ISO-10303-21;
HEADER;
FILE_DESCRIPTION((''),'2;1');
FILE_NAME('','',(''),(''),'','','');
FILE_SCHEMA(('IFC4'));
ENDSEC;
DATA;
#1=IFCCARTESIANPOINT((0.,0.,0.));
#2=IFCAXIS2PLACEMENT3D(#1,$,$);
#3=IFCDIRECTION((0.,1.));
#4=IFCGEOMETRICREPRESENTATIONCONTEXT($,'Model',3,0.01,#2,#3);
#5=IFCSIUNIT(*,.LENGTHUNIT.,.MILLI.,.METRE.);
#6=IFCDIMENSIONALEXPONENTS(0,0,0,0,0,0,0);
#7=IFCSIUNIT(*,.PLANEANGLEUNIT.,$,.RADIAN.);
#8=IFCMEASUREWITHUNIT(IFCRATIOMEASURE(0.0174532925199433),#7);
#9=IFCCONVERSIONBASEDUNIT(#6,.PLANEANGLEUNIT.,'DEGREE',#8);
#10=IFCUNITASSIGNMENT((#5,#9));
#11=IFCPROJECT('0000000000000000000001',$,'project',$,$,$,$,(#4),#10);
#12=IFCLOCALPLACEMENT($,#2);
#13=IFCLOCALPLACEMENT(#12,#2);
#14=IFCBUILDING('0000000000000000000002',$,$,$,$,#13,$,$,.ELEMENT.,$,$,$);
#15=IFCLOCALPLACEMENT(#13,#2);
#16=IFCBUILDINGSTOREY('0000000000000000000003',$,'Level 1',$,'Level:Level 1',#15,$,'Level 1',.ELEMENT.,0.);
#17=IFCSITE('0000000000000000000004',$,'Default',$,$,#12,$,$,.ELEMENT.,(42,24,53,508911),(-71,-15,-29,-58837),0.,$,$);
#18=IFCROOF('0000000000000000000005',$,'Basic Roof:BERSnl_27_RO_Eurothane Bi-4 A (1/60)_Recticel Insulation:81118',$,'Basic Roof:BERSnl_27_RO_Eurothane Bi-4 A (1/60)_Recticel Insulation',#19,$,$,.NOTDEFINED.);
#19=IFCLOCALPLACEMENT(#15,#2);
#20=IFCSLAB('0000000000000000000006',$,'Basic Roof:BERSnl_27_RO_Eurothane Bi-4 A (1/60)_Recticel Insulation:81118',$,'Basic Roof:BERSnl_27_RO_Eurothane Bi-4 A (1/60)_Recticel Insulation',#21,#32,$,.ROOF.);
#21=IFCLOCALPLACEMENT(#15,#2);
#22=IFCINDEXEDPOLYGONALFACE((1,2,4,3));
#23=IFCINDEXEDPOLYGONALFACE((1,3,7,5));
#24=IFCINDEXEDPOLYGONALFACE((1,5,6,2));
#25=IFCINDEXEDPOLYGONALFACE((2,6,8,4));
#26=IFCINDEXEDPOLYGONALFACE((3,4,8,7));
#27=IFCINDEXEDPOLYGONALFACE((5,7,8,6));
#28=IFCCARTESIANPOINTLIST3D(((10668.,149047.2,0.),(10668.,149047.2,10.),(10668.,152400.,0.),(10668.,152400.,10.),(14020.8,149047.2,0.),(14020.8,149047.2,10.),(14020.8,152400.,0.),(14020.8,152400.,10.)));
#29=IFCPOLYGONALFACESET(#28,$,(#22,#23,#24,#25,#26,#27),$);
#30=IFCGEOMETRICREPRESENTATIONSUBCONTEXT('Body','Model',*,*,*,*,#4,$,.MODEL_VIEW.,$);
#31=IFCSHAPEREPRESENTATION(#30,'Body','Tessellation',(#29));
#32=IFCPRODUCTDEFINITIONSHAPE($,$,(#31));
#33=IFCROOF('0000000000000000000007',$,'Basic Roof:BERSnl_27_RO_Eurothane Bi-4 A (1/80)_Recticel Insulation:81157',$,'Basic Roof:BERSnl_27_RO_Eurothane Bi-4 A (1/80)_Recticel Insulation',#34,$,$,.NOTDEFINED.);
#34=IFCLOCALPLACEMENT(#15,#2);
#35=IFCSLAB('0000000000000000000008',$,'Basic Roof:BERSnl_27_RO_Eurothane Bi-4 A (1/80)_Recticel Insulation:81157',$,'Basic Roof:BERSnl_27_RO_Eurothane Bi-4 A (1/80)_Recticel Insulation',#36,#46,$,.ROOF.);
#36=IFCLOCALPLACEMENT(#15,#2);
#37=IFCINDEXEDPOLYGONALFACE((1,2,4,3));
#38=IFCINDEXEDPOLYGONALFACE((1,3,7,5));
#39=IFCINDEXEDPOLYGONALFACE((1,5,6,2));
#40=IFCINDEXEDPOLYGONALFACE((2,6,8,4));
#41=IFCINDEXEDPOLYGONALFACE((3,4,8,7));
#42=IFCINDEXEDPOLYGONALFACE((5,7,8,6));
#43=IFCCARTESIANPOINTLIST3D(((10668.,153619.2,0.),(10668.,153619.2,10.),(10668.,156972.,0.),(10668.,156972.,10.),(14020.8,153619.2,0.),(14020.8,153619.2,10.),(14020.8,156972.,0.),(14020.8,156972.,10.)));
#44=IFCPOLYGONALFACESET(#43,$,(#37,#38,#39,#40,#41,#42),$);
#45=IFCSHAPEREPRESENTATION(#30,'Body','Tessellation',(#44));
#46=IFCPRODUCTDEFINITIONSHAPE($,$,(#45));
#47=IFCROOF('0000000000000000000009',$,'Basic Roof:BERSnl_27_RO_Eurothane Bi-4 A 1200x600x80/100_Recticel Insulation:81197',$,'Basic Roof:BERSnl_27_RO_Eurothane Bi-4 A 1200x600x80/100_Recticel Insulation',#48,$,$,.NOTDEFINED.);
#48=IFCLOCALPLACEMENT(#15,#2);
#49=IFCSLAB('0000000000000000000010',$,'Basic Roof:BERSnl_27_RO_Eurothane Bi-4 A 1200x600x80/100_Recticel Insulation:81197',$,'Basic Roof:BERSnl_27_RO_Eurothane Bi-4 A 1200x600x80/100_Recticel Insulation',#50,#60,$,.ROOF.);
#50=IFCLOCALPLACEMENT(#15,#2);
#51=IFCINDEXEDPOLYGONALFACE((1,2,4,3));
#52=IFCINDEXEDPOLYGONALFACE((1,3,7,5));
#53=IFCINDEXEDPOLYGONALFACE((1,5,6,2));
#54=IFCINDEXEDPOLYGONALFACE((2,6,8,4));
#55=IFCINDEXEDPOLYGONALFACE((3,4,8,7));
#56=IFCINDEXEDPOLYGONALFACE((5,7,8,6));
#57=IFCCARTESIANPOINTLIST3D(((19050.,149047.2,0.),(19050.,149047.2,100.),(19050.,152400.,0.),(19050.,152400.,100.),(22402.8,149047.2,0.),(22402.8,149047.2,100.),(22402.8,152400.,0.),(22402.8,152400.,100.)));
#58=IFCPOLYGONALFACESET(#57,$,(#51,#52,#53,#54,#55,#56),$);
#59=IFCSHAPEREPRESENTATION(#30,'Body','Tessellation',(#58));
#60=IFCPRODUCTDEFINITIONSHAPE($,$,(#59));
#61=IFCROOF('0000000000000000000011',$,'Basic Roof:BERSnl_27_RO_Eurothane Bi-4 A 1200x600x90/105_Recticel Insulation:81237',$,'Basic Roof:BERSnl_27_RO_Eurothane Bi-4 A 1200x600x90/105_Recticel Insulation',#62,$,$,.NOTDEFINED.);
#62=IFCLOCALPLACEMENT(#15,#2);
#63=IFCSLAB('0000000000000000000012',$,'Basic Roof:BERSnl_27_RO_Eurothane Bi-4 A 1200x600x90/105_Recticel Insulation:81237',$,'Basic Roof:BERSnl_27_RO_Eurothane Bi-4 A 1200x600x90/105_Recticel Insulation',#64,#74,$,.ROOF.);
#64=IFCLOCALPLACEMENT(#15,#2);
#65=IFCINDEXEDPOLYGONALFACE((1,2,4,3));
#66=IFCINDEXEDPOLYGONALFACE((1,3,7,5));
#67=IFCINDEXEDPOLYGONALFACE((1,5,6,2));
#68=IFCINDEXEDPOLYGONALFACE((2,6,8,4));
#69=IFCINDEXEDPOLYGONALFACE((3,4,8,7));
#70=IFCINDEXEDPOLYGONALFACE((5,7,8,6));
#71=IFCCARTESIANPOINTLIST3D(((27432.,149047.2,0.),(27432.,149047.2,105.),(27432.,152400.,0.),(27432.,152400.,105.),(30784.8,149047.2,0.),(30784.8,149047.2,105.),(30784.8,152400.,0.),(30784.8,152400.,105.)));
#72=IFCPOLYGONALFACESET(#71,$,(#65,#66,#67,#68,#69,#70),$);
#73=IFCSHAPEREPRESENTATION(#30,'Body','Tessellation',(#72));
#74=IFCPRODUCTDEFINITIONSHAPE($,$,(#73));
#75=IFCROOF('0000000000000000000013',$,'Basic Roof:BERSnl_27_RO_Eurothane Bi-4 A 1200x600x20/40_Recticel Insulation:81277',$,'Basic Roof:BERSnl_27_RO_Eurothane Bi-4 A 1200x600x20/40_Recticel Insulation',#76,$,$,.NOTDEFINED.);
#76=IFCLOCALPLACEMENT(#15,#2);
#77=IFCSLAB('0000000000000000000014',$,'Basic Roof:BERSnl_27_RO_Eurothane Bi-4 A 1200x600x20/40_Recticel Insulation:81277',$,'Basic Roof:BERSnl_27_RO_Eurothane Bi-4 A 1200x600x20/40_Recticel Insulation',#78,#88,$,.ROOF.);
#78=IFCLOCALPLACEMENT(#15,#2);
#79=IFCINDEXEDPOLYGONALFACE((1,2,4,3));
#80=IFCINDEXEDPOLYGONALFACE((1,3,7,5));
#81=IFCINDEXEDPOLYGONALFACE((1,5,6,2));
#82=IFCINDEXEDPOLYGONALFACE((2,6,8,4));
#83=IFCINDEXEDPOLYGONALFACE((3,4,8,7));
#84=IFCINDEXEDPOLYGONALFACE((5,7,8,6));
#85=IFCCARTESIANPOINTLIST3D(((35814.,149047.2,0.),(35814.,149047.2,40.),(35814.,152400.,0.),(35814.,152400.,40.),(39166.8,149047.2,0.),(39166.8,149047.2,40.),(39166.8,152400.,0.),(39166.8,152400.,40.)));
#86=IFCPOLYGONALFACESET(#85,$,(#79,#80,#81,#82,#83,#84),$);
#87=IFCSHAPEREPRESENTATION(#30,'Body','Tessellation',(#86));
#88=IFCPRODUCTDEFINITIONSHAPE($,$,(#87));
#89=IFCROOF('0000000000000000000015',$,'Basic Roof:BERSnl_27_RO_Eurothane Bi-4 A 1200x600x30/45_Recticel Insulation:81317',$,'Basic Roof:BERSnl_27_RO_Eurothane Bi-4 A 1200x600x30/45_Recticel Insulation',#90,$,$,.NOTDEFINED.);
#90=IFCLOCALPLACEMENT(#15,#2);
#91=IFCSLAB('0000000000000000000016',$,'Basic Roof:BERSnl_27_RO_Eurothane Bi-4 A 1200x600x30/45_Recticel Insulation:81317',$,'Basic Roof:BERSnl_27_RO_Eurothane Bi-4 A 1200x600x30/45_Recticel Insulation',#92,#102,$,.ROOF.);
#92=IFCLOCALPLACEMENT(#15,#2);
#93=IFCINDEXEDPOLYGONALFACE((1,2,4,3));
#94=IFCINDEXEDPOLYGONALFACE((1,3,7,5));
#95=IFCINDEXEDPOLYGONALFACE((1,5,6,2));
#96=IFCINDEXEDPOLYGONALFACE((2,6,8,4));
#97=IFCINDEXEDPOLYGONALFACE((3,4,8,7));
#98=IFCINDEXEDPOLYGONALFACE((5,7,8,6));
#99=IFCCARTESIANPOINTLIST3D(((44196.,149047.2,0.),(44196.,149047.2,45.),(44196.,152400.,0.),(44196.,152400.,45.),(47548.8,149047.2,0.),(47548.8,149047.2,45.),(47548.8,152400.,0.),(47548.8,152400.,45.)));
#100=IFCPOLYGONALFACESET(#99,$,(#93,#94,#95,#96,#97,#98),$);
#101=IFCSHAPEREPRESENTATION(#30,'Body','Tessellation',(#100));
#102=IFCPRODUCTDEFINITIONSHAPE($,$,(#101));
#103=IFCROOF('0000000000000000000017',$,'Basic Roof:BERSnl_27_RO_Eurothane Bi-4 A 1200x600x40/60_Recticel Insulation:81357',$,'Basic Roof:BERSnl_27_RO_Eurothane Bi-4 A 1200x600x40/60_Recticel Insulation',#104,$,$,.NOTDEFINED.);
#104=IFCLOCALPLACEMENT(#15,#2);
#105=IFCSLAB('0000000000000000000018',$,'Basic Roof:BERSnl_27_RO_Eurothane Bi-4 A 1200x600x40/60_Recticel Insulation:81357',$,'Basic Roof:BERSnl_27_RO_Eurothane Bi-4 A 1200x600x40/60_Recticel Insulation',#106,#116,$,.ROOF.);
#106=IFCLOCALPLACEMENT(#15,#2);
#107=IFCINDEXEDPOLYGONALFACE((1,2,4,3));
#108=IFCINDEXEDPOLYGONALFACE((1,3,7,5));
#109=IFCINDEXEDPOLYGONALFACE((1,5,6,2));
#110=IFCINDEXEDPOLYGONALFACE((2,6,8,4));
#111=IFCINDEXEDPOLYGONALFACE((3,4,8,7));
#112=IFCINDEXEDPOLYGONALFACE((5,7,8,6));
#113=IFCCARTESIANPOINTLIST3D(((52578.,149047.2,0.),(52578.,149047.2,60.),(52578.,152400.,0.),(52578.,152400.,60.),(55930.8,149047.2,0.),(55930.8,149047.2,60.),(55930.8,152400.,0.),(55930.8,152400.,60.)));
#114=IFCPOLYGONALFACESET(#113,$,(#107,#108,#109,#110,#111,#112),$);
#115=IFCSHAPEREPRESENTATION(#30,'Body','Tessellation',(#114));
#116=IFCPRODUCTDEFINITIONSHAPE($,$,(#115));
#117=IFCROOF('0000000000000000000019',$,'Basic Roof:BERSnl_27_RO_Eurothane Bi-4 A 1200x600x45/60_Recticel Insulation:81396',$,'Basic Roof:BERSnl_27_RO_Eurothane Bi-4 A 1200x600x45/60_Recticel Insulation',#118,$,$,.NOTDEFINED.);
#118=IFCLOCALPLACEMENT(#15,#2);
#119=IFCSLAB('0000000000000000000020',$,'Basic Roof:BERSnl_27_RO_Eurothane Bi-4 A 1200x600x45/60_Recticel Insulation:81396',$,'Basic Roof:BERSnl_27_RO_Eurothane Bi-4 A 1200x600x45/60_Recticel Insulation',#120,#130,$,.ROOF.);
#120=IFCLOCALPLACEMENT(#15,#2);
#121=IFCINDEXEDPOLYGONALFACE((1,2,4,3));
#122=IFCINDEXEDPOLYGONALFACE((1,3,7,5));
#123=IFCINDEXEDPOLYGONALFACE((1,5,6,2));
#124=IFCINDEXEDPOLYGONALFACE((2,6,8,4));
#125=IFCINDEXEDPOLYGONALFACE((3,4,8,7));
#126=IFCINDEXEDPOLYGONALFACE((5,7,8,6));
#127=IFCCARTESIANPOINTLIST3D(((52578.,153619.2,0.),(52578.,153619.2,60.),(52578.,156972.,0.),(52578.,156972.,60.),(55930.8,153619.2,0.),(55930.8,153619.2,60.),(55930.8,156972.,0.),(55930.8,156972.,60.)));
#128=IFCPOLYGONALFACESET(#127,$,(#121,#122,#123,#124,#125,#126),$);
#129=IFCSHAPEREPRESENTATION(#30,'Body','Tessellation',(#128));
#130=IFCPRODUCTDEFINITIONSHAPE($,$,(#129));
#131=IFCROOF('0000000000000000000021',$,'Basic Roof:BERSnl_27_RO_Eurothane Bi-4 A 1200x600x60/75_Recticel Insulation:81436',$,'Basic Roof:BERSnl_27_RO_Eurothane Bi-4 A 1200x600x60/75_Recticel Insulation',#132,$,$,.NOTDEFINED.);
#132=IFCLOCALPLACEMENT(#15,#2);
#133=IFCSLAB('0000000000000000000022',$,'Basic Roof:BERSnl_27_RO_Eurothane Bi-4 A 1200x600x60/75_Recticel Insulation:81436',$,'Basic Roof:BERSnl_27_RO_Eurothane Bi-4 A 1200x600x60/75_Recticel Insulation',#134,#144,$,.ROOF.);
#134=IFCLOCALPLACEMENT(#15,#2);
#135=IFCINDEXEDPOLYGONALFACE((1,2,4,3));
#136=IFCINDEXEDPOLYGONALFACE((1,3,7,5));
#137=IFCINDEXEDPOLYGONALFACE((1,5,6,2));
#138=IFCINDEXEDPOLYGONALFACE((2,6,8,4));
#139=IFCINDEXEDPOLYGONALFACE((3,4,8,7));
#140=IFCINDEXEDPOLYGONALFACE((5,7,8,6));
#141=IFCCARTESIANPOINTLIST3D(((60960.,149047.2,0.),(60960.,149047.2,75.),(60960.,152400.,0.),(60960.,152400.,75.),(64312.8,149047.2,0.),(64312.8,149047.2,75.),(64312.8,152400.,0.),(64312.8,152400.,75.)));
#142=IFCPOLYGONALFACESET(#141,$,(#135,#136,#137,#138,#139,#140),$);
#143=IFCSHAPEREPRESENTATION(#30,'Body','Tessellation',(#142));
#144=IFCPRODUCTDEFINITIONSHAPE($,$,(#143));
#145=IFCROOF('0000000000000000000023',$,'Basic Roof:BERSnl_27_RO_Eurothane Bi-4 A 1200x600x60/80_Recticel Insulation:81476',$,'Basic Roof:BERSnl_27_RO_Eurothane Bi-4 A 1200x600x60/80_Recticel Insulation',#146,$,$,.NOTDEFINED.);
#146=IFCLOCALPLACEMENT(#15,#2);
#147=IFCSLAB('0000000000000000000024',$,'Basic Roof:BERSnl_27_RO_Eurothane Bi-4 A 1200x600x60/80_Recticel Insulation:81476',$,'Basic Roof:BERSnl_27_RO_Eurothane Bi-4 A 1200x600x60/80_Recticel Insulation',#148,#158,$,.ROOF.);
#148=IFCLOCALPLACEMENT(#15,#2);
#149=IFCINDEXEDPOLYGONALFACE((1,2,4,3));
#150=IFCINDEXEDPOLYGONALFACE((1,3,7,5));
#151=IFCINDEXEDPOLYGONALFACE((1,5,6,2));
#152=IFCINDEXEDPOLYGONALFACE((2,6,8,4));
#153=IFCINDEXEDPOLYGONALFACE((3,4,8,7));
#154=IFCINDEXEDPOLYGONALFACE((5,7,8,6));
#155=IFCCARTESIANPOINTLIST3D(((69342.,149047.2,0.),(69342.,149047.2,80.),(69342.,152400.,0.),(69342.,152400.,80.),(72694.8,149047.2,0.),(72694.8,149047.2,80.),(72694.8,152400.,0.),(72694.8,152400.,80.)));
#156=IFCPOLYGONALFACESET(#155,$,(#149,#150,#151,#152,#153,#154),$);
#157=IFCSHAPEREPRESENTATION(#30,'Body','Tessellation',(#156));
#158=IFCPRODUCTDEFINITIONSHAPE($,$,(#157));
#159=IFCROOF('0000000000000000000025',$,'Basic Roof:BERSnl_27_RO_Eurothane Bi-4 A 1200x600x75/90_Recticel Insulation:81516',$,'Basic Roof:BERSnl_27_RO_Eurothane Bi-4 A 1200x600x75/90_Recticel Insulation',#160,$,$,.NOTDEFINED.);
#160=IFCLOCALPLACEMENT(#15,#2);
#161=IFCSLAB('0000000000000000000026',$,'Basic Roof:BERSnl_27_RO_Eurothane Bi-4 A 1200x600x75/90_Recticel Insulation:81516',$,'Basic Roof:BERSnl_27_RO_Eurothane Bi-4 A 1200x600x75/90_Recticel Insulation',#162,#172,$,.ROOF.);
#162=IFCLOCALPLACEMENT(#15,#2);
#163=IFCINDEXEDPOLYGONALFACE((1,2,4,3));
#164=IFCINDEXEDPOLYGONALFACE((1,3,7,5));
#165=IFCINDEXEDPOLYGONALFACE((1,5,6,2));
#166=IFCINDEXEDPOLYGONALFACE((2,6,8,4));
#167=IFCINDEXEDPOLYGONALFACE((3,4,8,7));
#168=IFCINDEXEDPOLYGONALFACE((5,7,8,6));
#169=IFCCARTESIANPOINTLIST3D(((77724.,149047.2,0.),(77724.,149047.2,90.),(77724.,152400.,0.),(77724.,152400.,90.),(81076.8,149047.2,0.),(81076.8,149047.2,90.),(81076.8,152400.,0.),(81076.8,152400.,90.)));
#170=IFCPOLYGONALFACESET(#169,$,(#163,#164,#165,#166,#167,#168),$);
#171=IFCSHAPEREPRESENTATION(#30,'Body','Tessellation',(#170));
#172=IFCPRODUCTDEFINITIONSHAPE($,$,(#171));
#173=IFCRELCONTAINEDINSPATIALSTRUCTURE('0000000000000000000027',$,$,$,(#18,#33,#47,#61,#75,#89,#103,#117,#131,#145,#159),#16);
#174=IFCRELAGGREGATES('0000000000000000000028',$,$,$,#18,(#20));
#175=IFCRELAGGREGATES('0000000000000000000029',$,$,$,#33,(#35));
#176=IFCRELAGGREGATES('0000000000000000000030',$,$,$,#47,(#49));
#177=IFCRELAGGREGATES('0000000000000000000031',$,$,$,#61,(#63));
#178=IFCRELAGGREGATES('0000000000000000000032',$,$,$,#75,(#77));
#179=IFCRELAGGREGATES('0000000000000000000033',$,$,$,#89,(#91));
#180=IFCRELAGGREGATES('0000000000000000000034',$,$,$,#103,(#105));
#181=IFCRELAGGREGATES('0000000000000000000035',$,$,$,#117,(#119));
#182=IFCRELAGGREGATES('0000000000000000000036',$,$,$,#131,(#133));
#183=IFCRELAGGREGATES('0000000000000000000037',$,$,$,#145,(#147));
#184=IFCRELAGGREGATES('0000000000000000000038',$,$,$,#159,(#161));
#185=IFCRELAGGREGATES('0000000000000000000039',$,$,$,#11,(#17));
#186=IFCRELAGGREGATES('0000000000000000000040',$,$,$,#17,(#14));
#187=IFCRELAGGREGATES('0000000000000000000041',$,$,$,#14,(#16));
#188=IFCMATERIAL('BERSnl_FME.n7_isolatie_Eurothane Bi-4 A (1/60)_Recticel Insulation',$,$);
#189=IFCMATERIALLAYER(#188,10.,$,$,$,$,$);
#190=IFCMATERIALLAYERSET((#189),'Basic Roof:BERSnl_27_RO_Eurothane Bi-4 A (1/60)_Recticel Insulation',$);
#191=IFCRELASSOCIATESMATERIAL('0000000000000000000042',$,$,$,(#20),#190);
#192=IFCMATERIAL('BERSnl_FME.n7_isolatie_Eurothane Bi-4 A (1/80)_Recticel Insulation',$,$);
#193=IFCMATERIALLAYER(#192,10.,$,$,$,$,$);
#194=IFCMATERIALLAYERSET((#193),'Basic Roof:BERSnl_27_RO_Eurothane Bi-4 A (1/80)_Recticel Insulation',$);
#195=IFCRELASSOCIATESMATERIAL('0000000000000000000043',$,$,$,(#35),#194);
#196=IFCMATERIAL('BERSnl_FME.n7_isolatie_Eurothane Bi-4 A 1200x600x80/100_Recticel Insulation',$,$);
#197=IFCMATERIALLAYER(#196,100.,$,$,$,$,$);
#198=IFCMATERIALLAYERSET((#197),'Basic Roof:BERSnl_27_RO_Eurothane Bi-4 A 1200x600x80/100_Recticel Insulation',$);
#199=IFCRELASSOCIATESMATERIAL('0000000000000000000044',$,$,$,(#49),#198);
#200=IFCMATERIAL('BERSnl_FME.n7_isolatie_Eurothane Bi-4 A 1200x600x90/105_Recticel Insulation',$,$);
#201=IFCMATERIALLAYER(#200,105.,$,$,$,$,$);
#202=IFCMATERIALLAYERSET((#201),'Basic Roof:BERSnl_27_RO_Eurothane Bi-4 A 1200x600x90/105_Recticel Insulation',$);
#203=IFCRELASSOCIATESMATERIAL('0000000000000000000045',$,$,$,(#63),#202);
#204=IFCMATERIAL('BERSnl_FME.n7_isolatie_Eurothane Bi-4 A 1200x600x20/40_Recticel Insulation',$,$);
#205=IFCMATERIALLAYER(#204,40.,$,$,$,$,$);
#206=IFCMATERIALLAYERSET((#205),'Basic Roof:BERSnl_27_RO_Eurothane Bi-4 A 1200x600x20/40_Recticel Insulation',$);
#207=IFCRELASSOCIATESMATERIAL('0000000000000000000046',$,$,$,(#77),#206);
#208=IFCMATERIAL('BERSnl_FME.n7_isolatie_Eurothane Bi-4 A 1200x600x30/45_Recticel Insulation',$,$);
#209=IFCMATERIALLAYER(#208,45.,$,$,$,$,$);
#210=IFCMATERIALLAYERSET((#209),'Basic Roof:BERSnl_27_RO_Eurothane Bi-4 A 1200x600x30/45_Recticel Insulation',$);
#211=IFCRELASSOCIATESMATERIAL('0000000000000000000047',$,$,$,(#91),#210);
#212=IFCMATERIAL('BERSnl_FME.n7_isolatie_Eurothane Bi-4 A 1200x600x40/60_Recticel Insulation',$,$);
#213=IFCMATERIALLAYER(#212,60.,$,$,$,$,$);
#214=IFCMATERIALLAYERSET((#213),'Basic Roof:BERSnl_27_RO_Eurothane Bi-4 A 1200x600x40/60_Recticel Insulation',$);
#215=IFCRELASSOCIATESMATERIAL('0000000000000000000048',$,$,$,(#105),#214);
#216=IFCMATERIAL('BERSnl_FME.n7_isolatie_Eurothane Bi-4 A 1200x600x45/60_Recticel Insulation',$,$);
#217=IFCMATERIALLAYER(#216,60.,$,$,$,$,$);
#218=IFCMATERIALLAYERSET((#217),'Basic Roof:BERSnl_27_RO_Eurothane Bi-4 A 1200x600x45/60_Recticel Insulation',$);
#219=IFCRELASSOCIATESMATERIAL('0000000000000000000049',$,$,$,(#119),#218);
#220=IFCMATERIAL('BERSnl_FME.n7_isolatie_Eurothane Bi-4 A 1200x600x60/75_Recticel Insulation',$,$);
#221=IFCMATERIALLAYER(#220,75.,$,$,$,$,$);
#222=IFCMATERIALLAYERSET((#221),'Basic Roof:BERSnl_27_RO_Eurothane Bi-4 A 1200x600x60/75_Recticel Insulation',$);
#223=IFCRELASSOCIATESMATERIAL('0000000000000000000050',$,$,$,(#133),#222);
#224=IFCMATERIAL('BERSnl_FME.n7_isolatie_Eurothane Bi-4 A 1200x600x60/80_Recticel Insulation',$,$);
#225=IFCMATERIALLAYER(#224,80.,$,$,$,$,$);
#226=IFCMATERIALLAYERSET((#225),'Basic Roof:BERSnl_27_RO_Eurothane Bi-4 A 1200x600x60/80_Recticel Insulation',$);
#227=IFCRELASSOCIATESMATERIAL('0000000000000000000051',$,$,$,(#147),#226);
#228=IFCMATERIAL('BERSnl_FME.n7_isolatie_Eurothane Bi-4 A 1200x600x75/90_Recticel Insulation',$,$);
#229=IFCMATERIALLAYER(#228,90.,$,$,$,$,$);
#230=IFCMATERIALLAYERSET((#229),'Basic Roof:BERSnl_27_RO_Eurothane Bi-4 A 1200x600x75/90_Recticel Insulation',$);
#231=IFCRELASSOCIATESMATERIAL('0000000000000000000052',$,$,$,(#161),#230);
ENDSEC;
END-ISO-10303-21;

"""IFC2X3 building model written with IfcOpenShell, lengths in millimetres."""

from ifc_helpers import new_model, entity, si_unit, converted_unit, direction, frame, frame_2d, origin, place, context, subcontext, project, spatial, rectangle, extrude, material, layer, layer_set, element, aggregate, save


model = new_model("IFC2X3")

# Units and contexts
model_context = context("Model", 3, precision=0.01, world=origin(), true_north=direction((0.0, 1.0)))
body_context = subcontext(model_context, "Body", "Model", "MODEL_VIEW")
ifc_project = project(units=[si_unit("LENGTHUNIT", "METRE", prefix="MILLI"), converted_unit("PLANEANGLEUNIT", "DEGREE", entity("IfcRatioMeasure", 0.0174532925199433), si_unit("PLANEANGLEUNIT", "RADIAN"), dimensions=[0, 0, 0, 0, 0, 0, 0])], contexts=[model_context])

# Site, building, storey
site_placement = place(None, origin())
site = spatial("IfcSite", under=ifc_project, at=site_placement, Name="Default", CompositionType="ELEMENT", RefLatitude=(42, 24, 53, 508911), RefLongitude=(-71, -15, -29, -58837), RefElevation=0.0)
building_placement = place(site_placement, origin())
building = spatial("IfcBuilding", under=site, at=building_placement, CompositionType="ELEMENT")
storey_placement = place(building_placement, origin())
storey = spatial("IfcBuildingStorey", under=building, at=storey_placement, Name="Level 1", ObjectType="Level:Level 1", LongName="Level 1", CompositionType="ELEMENT", Elevation=0.0)

# Roofs, slabs
roof_1_placement = place(storey_placement, frame((10668.0, 149047.2, 0.0)))
roof_1 = element("IfcRoof", 1, at=roof_1_placement, inside=storey, Name="Basic Roof:BERSnl_27_RO_Eurothane Bi-4 A (1/60)_Recticel Insulation:81118", ObjectType="Basic Roof:BERSnl_27_RO_Eurothane Bi-4 A (1/60)_Recticel Insulation", ShapeType="NOTDEFINED")
ifc_material_1 = material(Name="BERSnl_FME.n7_isolatie_Eurothane Bi-4 A (1/60)_Recticel Insulation")
ifc_layer_1 = layer(ifc_material_1, 10.0)
ifc_layer_set_1 = layer_set([ifc_layer_1], Name="Basic Roof:BERSnl_27_RO_Eurothane Bi-4 A (1/60)_Recticel Insulation")
slab_1_placement = place(roof_1_placement, origin())
slab_1 = element("IfcSlab", 2, at=slab_1_placement, material=ifc_layer_set_1, Name="Basic Roof:BERSnl_27_RO_Eurothane Bi-4 A (1/60)_Recticel Insulation:81118", ObjectType="Basic Roof:BERSnl_27_RO_Eurothane Bi-4 A (1/60)_Recticel Insulation", PredefinedType="ROOF", context=body_context, shape_type="SweptSolid", body=[
    extrude(rectangle(XDim=3352.8, YDim=3352.8, at=frame_2d((0.0, 0.0), x_axis=(-1.0, 0.0))), frame((1676.4, 1676.4, 0.0)), (0.0, 0.0, 1.0), 10.0),
])
aggregate(roof_1, [slab_1])
roof_2_placement = place(storey_placement, frame((10668.0, 153619.2, 0.0)))
roof_2 = element("IfcRoof", 3, at=roof_2_placement, inside=storey, Name="Basic Roof:BERSnl_27_RO_Eurothane Bi-4 A (1/80)_Recticel Insulation:81157", ObjectType="Basic Roof:BERSnl_27_RO_Eurothane Bi-4 A (1/80)_Recticel Insulation", ShapeType="NOTDEFINED")
ifc_material_2 = material(Name="BERSnl_FME.n7_isolatie_Eurothane Bi-4 A (1/80)_Recticel Insulation")
ifc_layer_2 = layer(ifc_material_2, 10.0)
ifc_layer_set_2 = layer_set([ifc_layer_2], Name="Basic Roof:BERSnl_27_RO_Eurothane Bi-4 A (1/80)_Recticel Insulation")
slab_2_placement = place(roof_2_placement, origin())
slab_2 = element("IfcSlab", 4, at=slab_2_placement, material=ifc_layer_set_2, Name="Basic Roof:BERSnl_27_RO_Eurothane Bi-4 A (1/80)_Recticel Insulation:81157", ObjectType="Basic Roof:BERSnl_27_RO_Eurothane Bi-4 A (1/80)_Recticel Insulation", PredefinedType="ROOF", context=body_context, shape_type="SweptSolid", body=[
    extrude(rectangle(XDim=3352.8, YDim=3352.8, at=frame_2d((0.0, 0.0), x_axis=(-1.0, 0.0))), frame((1676.4, 1676.4, 0.0)), (0.0, 0.0, 1.0), 10.0),
])
aggregate(roof_2, [slab_2])
roof_3_placement = place(storey_placement, frame((19050.0, 149047.2, 0.0)))
roof_3 = element("IfcRoof", 5, at=roof_3_placement, inside=storey, Name="Basic Roof:BERSnl_27_RO_Eurothane Bi-4 A 1200x600x80/100_Recticel Insulation:81197", ObjectType="Basic Roof:BERSnl_27_RO_Eurothane Bi-4 A 1200x600x80/100_Recticel Insulation", ShapeType="NOTDEFINED")
ifc_material_3 = material(Name="BERSnl_FME.n7_isolatie_Eurothane Bi-4 A 1200x600x80/100_Recticel Insulation")
ifc_layer_3 = layer(ifc_material_3, 100.0)
ifc_layer_set_3 = layer_set([ifc_layer_3], Name="Basic Roof:BERSnl_27_RO_Eurothane Bi-4 A 1200x600x80/100_Recticel Insulation")
slab_3_placement = place(roof_3_placement, origin())
slab_3 = element("IfcSlab", 6, at=slab_3_placement, material=ifc_layer_set_3, Name="Basic Roof:BERSnl_27_RO_Eurothane Bi-4 A 1200x600x80/100_Recticel Insulation:81197", ObjectType="Basic Roof:BERSnl_27_RO_Eurothane Bi-4 A 1200x600x80/100_Recticel Insulation", PredefinedType="ROOF", context=body_context, shape_type="SweptSolid", body=[
    extrude(rectangle(XDim=3352.8, YDim=3352.8, at=frame_2d((0.0, 0.0), x_axis=(-1.0, 0.0))), frame((1676.4, 1676.4, 0.0)), (0.0, 0.0, 1.0), 100.0),
])
aggregate(roof_3, [slab_3])
roof_4_placement = place(storey_placement, frame((27432.0, 149047.2, 0.0)))
roof_4 = element("IfcRoof", 7, at=roof_4_placement, inside=storey, Name="Basic Roof:BERSnl_27_RO_Eurothane Bi-4 A 1200x600x90/105_Recticel Insulation:81237", ObjectType="Basic Roof:BERSnl_27_RO_Eurothane Bi-4 A 1200x600x90/105_Recticel Insulation", ShapeType="NOTDEFINED")
ifc_material_4 = material(Name="BERSnl_FME.n7_isolatie_Eurothane Bi-4 A 1200x600x90/105_Recticel Insulation")
ifc_layer_4 = layer(ifc_material_4, 105.0)
ifc_layer_set_4 = layer_set([ifc_layer_4], Name="Basic Roof:BERSnl_27_RO_Eurothane Bi-4 A 1200x600x90/105_Recticel Insulation")
slab_4_placement = place(roof_4_placement, origin())
slab_4 = element("IfcSlab", 8, at=slab_4_placement, material=ifc_layer_set_4, Name="Basic Roof:BERSnl_27_RO_Eurothane Bi-4 A 1200x600x90/105_Recticel Insulation:81237", ObjectType="Basic Roof:BERSnl_27_RO_Eurothane Bi-4 A 1200x600x90/105_Recticel Insulation", PredefinedType="ROOF", context=body_context, shape_type="SweptSolid", body=[
    extrude(rectangle(XDim=3352.8, YDim=3352.8, at=frame_2d((0.0, 0.0), x_axis=(-1.0, 0.0))), frame((1676.4, 1676.4, 0.0)), (0.0, 0.0, 1.0), 105.0),
])
aggregate(roof_4, [slab_4])
roof_5_placement = place(storey_placement, frame((35814.0, 149047.2, 0.0)))
roof_5 = element("IfcRoof", 9, at=roof_5_placement, inside=storey, Name="Basic Roof:BERSnl_27_RO_Eurothane Bi-4 A 1200x600x20/40_Recticel Insulation:81277", ObjectType="Basic Roof:BERSnl_27_RO_Eurothane Bi-4 A 1200x600x20/40_Recticel Insulation", ShapeType="NOTDEFINED")
ifc_material_5 = material(Name="BERSnl_FME.n7_isolatie_Eurothane Bi-4 A 1200x600x20/40_Recticel Insulation")
ifc_layer_5 = layer(ifc_material_5, 40.0)
ifc_layer_set_5 = layer_set([ifc_layer_5], Name="Basic Roof:BERSnl_27_RO_Eurothane Bi-4 A 1200x600x20/40_Recticel Insulation")
slab_5_placement = place(roof_5_placement, origin())
slab_5 = element("IfcSlab", 10, at=slab_5_placement, material=ifc_layer_set_5, Name="Basic Roof:BERSnl_27_RO_Eurothane Bi-4 A 1200x600x20/40_Recticel Insulation:81277", ObjectType="Basic Roof:BERSnl_27_RO_Eurothane Bi-4 A 1200x600x20/40_Recticel Insulation", PredefinedType="ROOF", context=body_context, shape_type="SweptSolid", body=[
    extrude(rectangle(XDim=3352.8, YDim=3352.8, at=frame_2d((0.0, 0.0), x_axis=(-1.0, 0.0))), frame((1676.4, 1676.4, 0.0)), (0.0, 0.0, 1.0), 40.0),
])
aggregate(roof_5, [slab_5])
roof_6_placement = place(storey_placement, frame((44196.0, 149047.2, 0.0)))
roof_6 = element("IfcRoof", 11, at=roof_6_placement, inside=storey, Name="Basic Roof:BERSnl_27_RO_Eurothane Bi-4 A 1200x600x30/45_Recticel Insulation:81317", ObjectType="Basic Roof:BERSnl_27_RO_Eurothane Bi-4 A 1200x600x30/45_Recticel Insulation", ShapeType="NOTDEFINED")
ifc_material_6 = material(Name="BERSnl_FME.n7_isolatie_Eurothane Bi-4 A 1200x600x30/45_Recticel Insulation")
ifc_layer_6 = layer(ifc_material_6, 45.0)
ifc_layer_set_6 = layer_set([ifc_layer_6], Name="Basic Roof:BERSnl_27_RO_Eurothane Bi-4 A 1200x600x30/45_Recticel Insulation")
slab_6_placement = place(roof_6_placement, origin())
slab_6 = element("IfcSlab", 12, at=slab_6_placement, material=ifc_layer_set_6, Name="Basic Roof:BERSnl_27_RO_Eurothane Bi-4 A 1200x600x30/45_Recticel Insulation:81317", ObjectType="Basic Roof:BERSnl_27_RO_Eurothane Bi-4 A 1200x600x30/45_Recticel Insulation", PredefinedType="ROOF", context=body_context, shape_type="SweptSolid", body=[
    extrude(rectangle(XDim=3352.8, YDim=3352.8, at=frame_2d((0.0, 0.0), x_axis=(-1.0, 0.0))), frame((1676.4, 1676.4, 0.0)), (0.0, 0.0, 1.0), 45.0),
])
aggregate(roof_6, [slab_6])
roof_7_placement = place(storey_placement, frame((52578.0, 149047.2, 0.0)))
roof_7 = element("IfcRoof", 13, at=roof_7_placement, inside=storey, Name="Basic Roof:BERSnl_27_RO_Eurothane Bi-4 A 1200x600x40/60_Recticel Insulation:81357", ObjectType="Basic Roof:BERSnl_27_RO_Eurothane Bi-4 A 1200x600x40/60_Recticel Insulation", ShapeType="NOTDEFINED")
ifc_material_7 = material(Name="BERSnl_FME.n7_isolatie_Eurothane Bi-4 A 1200x600x40/60_Recticel Insulation")
ifc_layer_7 = layer(ifc_material_7, 60.0)
ifc_layer_set_7 = layer_set([ifc_layer_7], Name="Basic Roof:BERSnl_27_RO_Eurothane Bi-4 A 1200x600x40/60_Recticel Insulation")
slab_7_placement = place(roof_7_placement, origin())
slab_7 = element("IfcSlab", 14, at=slab_7_placement, material=ifc_layer_set_7, Name="Basic Roof:BERSnl_27_RO_Eurothane Bi-4 A 1200x600x40/60_Recticel Insulation:81357", ObjectType="Basic Roof:BERSnl_27_RO_Eurothane Bi-4 A 1200x600x40/60_Recticel Insulation", PredefinedType="ROOF", context=body_context, shape_type="SweptSolid", body=[
    extrude(rectangle(XDim=3352.8, YDim=3352.8, at=frame_2d((0.0, 0.0), x_axis=(-1.0, 0.0))), frame((1676.4, 1676.4, 0.0)), (0.0, 0.0, 1.0), 60.0),
])
aggregate(roof_7, [slab_7])
roof_8_placement = place(storey_placement, frame((52578.0, 153619.2, 0.0)))
roof_8 = element("IfcRoof", 15, at=roof_8_placement, inside=storey, Name="Basic Roof:BERSnl_27_RO_Eurothane Bi-4 A 1200x600x45/60_Recticel Insulation:81396", ObjectType="Basic Roof:BERSnl_27_RO_Eurothane Bi-4 A 1200x600x45/60_Recticel Insulation", ShapeType="NOTDEFINED")
ifc_material_8 = material(Name="BERSnl_FME.n7_isolatie_Eurothane Bi-4 A 1200x600x45/60_Recticel Insulation")
ifc_layer_8 = layer(ifc_material_8, 60.0)
ifc_layer_set_8 = layer_set([ifc_layer_8], Name="Basic Roof:BERSnl_27_RO_Eurothane Bi-4 A 1200x600x45/60_Recticel Insulation")
slab_8_placement = place(roof_8_placement, origin())
slab_8 = element("IfcSlab", 16, at=slab_8_placement, material=ifc_layer_set_8, Name="Basic Roof:BERSnl_27_RO_Eurothane Bi-4 A 1200x600x45/60_Recticel Insulation:81396", ObjectType="Basic Roof:BERSnl_27_RO_Eurothane Bi-4 A 1200x600x45/60_Recticel Insulation", PredefinedType="ROOF", context=body_context, shape_type="SweptSolid", body=[
    extrude(rectangle(XDim=3352.8, YDim=3352.8, at=frame_2d((0.0, 0.0), x_axis=(-1.0, 0.0))), frame((1676.4, 1676.4, 0.0)), (0.0, 0.0, 1.0), 60.0),
])
aggregate(roof_8, [slab_8])
roof_9_placement = place(storey_placement, frame((60960.0, 149047.2, 0.0)))
roof_9 = element("IfcRoof", 17, at=roof_9_placement, inside=storey, Name="Basic Roof:BERSnl_27_RO_Eurothane Bi-4 A 1200x600x60/75_Recticel Insulation:81436", ObjectType="Basic Roof:BERSnl_27_RO_Eurothane Bi-4 A 1200x600x60/75_Recticel Insulation", ShapeType="NOTDEFINED")
ifc_material_9 = material(Name="BERSnl_FME.n7_isolatie_Eurothane Bi-4 A 1200x600x60/75_Recticel Insulation")
ifc_layer_9 = layer(ifc_material_9, 75.0)
ifc_layer_set_9 = layer_set([ifc_layer_9], Name="Basic Roof:BERSnl_27_RO_Eurothane Bi-4 A 1200x600x60/75_Recticel Insulation")
slab_9_placement = place(roof_9_placement, origin())
slab_9 = element("IfcSlab", 18, at=slab_9_placement, material=ifc_layer_set_9, Name="Basic Roof:BERSnl_27_RO_Eurothane Bi-4 A 1200x600x60/75_Recticel Insulation:81436", ObjectType="Basic Roof:BERSnl_27_RO_Eurothane Bi-4 A 1200x600x60/75_Recticel Insulation", PredefinedType="ROOF", context=body_context, shape_type="SweptSolid", body=[
    extrude(rectangle(XDim=3352.8, YDim=3352.8, at=frame_2d((0.0, 0.0), x_axis=(-1.0, 0.0))), frame((1676.4, 1676.4, 0.0)), (0.0, 0.0, 1.0), 75.0),
])
aggregate(roof_9, [slab_9])
roof_10_placement = place(storey_placement, frame((69342.0, 149047.2, 0.0)))
roof_10 = element("IfcRoof", 19, at=roof_10_placement, inside=storey, Name="Basic Roof:BERSnl_27_RO_Eurothane Bi-4 A 1200x600x60/80_Recticel Insulation:81476", ObjectType="Basic Roof:BERSnl_27_RO_Eurothane Bi-4 A 1200x600x60/80_Recticel Insulation", ShapeType="NOTDEFINED")
ifc_material_10 = material(Name="BERSnl_FME.n7_isolatie_Eurothane Bi-4 A 1200x600x60/80_Recticel Insulation")
ifc_layer_10 = layer(ifc_material_10, 80.0)
ifc_layer_set_10 = layer_set([ifc_layer_10], Name="Basic Roof:BERSnl_27_RO_Eurothane Bi-4 A 1200x600x60/80_Recticel Insulation")
slab_10_placement = place(roof_10_placement, origin())
slab_10 = element("IfcSlab", 20, at=slab_10_placement, material=ifc_layer_set_10, Name="Basic Roof:BERSnl_27_RO_Eurothane Bi-4 A 1200x600x60/80_Recticel Insulation:81476", ObjectType="Basic Roof:BERSnl_27_RO_Eurothane Bi-4 A 1200x600x60/80_Recticel Insulation", PredefinedType="ROOF", context=body_context, shape_type="SweptSolid", body=[
    extrude(rectangle(XDim=3352.8, YDim=3352.8, at=frame_2d((0.0, 0.0), x_axis=(-1.0, 0.0))), frame((1676.4, 1676.4, 0.0)), (0.0, 0.0, 1.0), 80.0),
])
aggregate(roof_10, [slab_10])
roof_11_placement = place(storey_placement, frame((77724.0, 149047.2, 0.0)))
roof_11 = element("IfcRoof", 21, at=roof_11_placement, inside=storey, Name="Basic Roof:BERSnl_27_RO_Eurothane Bi-4 A 1200x600x75/90_Recticel Insulation:81516", ObjectType="Basic Roof:BERSnl_27_RO_Eurothane Bi-4 A 1200x600x75/90_Recticel Insulation", ShapeType="NOTDEFINED")
ifc_material_11 = material(Name="BERSnl_FME.n7_isolatie_Eurothane Bi-4 A 1200x600x75/90_Recticel Insulation")
ifc_layer_11 = layer(ifc_material_11, 90.0)
ifc_layer_set_11 = layer_set([ifc_layer_11], Name="Basic Roof:BERSnl_27_RO_Eurothane Bi-4 A 1200x600x75/90_Recticel Insulation")
slab_11_placement = place(roof_11_placement, origin())
slab_11 = element("IfcSlab", 22, at=slab_11_placement, material=ifc_layer_set_11, Name="Basic Roof:BERSnl_27_RO_Eurothane Bi-4 A 1200x600x75/90_Recticel Insulation:81516", ObjectType="Basic Roof:BERSnl_27_RO_Eurothane Bi-4 A 1200x600x75/90_Recticel Insulation", PredefinedType="ROOF", context=body_context, shape_type="SweptSolid", body=[
    extrude(rectangle(XDim=3352.8, YDim=3352.8, at=frame_2d((0.0, 0.0), x_axis=(-1.0, 0.0))), frame((1676.4, 1676.4, 0.0)), (0.0, 0.0, 1.0), 90.0),
])
aggregate(roof_11, [slab_11])

save(model, "model.ifc")
